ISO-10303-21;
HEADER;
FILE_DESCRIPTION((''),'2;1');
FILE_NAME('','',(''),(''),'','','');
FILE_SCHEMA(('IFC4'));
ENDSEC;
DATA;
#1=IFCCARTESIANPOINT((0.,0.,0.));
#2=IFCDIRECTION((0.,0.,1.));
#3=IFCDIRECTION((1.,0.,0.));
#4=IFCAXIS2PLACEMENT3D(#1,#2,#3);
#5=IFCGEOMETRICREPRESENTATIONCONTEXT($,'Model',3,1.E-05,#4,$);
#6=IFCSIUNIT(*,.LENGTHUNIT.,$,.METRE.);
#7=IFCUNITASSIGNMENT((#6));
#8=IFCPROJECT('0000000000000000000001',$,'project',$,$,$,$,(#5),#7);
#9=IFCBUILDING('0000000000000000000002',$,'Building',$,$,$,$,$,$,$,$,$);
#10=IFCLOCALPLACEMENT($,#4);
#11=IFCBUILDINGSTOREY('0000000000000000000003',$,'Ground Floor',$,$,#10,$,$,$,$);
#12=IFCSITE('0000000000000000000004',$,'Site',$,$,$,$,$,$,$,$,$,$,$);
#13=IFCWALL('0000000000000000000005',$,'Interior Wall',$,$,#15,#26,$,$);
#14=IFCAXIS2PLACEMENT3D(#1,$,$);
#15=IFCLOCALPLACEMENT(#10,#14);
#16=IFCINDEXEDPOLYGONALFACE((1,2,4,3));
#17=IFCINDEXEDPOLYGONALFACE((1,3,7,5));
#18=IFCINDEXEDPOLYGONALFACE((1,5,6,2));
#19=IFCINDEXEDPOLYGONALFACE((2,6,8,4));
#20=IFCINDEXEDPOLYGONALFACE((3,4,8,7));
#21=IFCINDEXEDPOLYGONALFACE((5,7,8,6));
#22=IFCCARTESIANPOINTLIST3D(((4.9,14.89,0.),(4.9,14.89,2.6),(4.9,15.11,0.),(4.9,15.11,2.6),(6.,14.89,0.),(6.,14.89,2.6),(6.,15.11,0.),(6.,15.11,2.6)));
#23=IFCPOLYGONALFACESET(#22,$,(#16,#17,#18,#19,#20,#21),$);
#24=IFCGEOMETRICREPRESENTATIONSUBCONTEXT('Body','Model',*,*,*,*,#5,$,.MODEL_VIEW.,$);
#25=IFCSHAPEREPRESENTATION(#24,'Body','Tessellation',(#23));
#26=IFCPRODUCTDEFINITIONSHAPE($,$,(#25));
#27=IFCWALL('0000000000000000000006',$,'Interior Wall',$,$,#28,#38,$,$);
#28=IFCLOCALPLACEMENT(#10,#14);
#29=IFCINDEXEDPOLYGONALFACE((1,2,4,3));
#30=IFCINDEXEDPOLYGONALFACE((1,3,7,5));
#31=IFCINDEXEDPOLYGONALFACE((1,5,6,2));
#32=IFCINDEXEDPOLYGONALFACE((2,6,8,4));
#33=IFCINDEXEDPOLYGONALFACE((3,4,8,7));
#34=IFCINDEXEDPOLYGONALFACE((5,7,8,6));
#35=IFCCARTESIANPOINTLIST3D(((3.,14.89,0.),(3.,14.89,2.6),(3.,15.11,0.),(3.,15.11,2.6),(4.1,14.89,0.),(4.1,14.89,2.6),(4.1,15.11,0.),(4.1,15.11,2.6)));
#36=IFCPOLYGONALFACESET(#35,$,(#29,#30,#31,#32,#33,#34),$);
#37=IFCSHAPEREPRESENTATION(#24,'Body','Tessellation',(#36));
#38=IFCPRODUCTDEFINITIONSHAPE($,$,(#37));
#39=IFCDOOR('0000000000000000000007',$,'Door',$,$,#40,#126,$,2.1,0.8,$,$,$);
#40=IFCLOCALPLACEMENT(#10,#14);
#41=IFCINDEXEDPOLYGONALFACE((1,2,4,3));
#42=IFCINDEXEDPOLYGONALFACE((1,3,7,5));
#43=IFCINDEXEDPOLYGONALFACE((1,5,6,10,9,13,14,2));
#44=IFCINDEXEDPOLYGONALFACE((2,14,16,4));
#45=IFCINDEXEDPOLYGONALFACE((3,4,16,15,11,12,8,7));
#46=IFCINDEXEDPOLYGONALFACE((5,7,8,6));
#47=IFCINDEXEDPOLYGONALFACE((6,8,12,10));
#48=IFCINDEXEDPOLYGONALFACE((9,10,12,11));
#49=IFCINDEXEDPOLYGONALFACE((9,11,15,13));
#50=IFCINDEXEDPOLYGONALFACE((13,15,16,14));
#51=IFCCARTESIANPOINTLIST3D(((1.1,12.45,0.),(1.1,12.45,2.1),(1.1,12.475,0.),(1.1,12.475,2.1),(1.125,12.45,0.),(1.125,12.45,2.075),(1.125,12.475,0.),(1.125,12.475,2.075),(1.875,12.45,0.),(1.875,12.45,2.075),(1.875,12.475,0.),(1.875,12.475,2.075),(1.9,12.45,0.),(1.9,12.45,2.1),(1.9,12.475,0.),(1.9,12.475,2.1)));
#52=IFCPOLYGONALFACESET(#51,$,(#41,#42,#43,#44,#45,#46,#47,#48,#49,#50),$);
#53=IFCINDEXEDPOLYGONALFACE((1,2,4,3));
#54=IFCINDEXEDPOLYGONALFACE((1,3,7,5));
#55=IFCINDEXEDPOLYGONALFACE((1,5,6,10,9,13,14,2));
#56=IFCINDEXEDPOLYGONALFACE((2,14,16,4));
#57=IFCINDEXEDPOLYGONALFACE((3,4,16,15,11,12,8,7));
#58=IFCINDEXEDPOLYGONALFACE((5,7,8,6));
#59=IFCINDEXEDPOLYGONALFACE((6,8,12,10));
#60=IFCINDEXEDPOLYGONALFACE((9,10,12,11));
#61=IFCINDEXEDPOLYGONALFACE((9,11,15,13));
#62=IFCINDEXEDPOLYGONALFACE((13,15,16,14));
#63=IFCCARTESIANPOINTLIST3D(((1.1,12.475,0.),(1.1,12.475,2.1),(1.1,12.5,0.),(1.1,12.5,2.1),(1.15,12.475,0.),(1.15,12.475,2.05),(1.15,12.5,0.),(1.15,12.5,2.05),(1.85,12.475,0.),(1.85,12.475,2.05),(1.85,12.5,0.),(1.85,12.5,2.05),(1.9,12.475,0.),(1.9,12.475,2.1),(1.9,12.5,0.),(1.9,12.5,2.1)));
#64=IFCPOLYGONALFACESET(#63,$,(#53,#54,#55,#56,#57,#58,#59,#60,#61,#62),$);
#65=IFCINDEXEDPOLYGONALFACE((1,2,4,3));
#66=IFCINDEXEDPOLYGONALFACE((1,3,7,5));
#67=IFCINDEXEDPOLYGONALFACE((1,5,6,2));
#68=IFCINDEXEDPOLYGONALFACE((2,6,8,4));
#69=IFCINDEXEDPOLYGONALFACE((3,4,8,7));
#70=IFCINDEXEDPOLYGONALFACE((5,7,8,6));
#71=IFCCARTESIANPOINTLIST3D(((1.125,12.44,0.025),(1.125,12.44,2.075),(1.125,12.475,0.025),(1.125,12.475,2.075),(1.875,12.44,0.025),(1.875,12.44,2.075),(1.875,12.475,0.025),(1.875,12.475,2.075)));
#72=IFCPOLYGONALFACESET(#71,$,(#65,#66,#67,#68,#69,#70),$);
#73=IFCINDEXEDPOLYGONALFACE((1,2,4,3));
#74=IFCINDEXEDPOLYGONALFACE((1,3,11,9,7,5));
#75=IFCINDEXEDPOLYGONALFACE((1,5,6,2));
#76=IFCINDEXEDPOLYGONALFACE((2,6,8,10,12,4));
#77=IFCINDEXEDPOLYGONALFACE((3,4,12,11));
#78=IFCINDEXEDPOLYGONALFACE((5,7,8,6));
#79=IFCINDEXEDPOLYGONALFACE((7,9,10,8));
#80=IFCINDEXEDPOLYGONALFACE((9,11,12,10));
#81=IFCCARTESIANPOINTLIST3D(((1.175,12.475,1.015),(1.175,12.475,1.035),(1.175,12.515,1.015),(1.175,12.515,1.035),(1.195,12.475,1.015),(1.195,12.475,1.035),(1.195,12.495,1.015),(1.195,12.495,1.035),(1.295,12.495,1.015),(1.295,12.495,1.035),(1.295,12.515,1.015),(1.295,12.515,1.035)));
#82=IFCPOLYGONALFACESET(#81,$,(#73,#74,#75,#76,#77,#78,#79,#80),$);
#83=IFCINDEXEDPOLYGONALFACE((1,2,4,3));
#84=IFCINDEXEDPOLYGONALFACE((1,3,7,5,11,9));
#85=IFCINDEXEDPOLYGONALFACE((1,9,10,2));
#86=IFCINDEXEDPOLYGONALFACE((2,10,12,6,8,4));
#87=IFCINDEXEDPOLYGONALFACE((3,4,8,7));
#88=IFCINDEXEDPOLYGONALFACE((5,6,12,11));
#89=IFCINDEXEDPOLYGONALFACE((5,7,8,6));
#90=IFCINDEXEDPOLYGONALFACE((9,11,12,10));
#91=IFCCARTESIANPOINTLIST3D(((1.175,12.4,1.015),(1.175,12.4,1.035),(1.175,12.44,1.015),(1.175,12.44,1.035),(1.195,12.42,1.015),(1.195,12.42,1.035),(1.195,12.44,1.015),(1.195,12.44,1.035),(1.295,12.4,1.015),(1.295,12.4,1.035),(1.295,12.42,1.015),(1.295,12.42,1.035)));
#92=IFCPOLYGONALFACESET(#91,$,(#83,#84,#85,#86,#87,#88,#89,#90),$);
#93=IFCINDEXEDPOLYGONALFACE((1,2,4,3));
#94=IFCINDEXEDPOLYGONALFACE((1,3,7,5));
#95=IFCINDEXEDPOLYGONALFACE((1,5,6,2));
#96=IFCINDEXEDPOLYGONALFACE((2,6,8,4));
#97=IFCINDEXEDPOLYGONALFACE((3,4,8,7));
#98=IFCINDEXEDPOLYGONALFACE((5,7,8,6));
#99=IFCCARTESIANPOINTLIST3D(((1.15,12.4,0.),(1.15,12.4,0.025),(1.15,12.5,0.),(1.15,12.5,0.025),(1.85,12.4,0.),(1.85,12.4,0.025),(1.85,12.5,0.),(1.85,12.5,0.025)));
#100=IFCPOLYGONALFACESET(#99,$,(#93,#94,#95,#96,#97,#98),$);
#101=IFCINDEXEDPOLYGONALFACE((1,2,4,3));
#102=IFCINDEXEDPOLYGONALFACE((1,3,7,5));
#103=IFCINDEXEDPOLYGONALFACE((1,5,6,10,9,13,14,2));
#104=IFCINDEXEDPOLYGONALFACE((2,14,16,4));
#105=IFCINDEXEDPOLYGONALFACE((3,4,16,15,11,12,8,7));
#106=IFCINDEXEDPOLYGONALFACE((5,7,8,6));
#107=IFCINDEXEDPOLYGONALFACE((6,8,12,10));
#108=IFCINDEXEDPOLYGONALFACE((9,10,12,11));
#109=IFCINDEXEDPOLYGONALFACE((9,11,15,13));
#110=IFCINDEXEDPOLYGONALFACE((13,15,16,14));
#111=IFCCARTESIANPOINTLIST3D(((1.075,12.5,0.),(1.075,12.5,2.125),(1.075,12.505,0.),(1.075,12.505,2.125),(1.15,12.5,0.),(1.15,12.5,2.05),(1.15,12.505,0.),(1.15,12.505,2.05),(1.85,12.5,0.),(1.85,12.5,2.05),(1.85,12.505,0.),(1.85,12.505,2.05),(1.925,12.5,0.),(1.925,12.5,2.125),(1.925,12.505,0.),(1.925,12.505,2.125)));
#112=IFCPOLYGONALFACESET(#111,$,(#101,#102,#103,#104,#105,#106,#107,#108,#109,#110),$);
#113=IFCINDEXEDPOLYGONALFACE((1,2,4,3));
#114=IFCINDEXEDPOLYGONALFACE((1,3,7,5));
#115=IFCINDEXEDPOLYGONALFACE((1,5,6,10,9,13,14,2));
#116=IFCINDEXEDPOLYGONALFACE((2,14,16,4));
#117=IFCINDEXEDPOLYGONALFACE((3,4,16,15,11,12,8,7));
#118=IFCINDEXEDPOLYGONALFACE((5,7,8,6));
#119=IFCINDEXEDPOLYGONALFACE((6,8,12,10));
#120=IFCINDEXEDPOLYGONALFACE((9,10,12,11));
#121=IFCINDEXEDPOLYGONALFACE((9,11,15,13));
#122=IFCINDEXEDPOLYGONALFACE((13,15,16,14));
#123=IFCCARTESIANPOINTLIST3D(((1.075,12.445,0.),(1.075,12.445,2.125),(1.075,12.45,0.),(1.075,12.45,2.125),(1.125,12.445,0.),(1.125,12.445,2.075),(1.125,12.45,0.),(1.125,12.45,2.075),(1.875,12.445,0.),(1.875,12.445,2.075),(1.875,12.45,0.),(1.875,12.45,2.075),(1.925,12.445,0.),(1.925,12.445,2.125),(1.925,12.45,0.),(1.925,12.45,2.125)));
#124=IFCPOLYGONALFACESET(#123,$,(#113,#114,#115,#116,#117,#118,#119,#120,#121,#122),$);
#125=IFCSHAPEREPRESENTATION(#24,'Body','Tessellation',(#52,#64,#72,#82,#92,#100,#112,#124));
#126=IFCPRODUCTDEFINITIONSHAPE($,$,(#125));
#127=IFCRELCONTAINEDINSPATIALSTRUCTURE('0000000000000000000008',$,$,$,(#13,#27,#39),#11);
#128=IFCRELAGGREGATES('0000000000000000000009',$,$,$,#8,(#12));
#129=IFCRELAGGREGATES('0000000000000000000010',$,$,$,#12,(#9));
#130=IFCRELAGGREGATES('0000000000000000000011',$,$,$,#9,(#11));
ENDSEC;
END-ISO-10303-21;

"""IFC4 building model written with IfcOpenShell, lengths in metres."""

from ifc_helpers import new_model, si_unit, frame, origin_with_axes, place, context, subcontext, project, spatial, line, indexed_curve, outline, extrude, element, save


model = new_model("IFC4")

# Units and contexts
model_context = context("Model", 3, precision=1e-05, world=origin_with_axes())
body_context = subcontext(model_context, "Body", "Model", "MODEL_VIEW")
ifc_project = project(units=[si_unit("LENGTHUNIT", "METRE")], contexts=[model_context])

# Site, building, storey
site = spatial("IfcSite", under=ifc_project, Name="Site")
building = spatial("IfcBuilding", under=site, Name="Building")
storey_placement = place(None, origin_with_axes())
storey = spatial("IfcBuildingStorey", under=building, at=storey_placement, Name="Ground Floor")

# Walls
for number, where, z_axis, x_axis, name in (
    (1, (6.0, 15.0, 0.0), (0.0, 0.0, 1.0), (-1.0, 0.0, 0.0), "Interior Wall"),
    (2, (4.1, 15.0, 0.0), (0.0, 0.0, 1.0), (-1.0, 0.0, 0.0), "Interior Wall"),
):
    element("IfcWall", number, at=place(storey_placement, frame(where, z_axis=z_axis, x_axis=x_axis)), inside=storey, Name=name, context=body_context, shape_type="SweptSolid", body=[
        extrude(outline(indexed_curve([(0.0, 0.0), (0.0, 0.22), (1.1, 0.22), (1.1, 0.0), (0.0, 0.0)], self_intersect=False)), frame((0.0, -0.11, 0.0), z_axis=(0.0, 0.0, 1.0), x_axis=(1.0, 0.0, 0.0)), (0.0, 0.0, 1.0), 2.6),
    ])

# Door
door_1_placement = place(storey_placement, frame((1.9, 12.5, 0.0), z_axis=(0.0, 0.0, 1.0), x_axis=(-1.0, 0.0, 0.0)))
element("IfcDoor", 3, at=door_1_placement, inside=storey, Name="Door", OverallHeight=2.1, OverallWidth=0.8, context=body_context, shape_type="SweptSolid", body=[
    extrude(outline(indexed_curve([(0.0, 0.0), (0.0, 2.1), (0.8, 2.1), (0.8, 0.0), (0.775, 0.0), (0.775, 2.075), (0.025, 2.075), (0.025, 0.0)], segments=[line(1, 2, 3, 4, 5, 6, 7, 8, 1)])), frame((0.0, 0.025, 0.0), z_axis=(0.0, -1.0, 0.0), x_axis=(1.0, 0.0, 0.0)), (0.0, 0.0, -1.0), 0.025),
    extrude(outline(indexed_curve([(0.0, 0.0), (0.0, 2.1), (0.8, 2.1), (0.8, 0.0), (0.75, 0.0), (0.75, 2.05), (0.05, 2.05), (0.05, 0.0)], segments=[line(1, 2, 3, 4, 5, 6, 7, 8, 1)])), frame((0.0, 0.0, 0.0), z_axis=(0.0, -1.0, 0.0), x_axis=(1.0, 0.0, 0.0)), (0.0, 0.0, -1.0), 0.025),
    extrude(outline(indexed_curve([(0.0, 0.0), (0.75, 0.0), (0.75, 0.035), (0.0, 0.035)], segments=[line(1, 2, 3, 4, 1)])), frame((0.025, 0.025, 0.025), z_axis=(0.0, 0.0, 1.0), x_axis=(1.0, 0.0, 0.0)), (0.0, 0.0, 1.0), 2.05),
    extrude(outline(indexed_curve([(0.0, 0.0), (0.0, -0.04), (-0.12, -0.04), (-0.12, -0.02), (-0.02, -0.02), (-0.02, 0.0)], segments=[line(1, 2, 3, 4, 5, 6, 1)])), frame((0.725, 0.025, 1.015), z_axis=(0.0, 0.0, 1.0), x_axis=(1.0, 0.0, 0.0)), (0.0, 0.0, 1.0), 0.02),
    extrude(outline(indexed_curve([(0.0, 0.0), (0.0, 0.04), (-0.12, 0.04), (-0.12, 0.02), (-0.02, 0.02), (-0.02, 0.0)], segments=[line(1, 2, 3, 4, 5, 6, 1)])), frame((0.725, 0.06, 1.015), z_axis=(0.0, 0.0, 1.0), x_axis=(1.0, 0.0, 0.0)), (0.0, 0.0, 1.0), 0.02),
    extrude(outline(indexed_curve([(0.0, 0.0), (0.7, 0.0), (0.7, 0.1), (0.0, 0.1)], segments=[line(1, 2, 3, 4, 1)])), frame((0.05, 0.0, 0.0), z_axis=(0.0, 0.0, 1.0), x_axis=(1.0, 0.0, 0.0)), (0.0, 0.0, 1.0), 0.025),
    extrude(outline(indexed_curve([(0.0, 0.0), (0.0, 2.125), (0.85, 2.125), (0.85, 0.0), (0.775, 0.0), (0.775, 2.05), (0.075, 2.05), (0.075, 0.0)], segments=[line(1, 2, 3, 4, 5, 6, 7, 8, 1)])), frame((-0.025, -0.005, 0.0), z_axis=(0.0, -1.0, 0.0), x_axis=(1.0, 0.0, 0.0)), (0.0, 0.0, -1.0), 0.005),
    extrude(outline(indexed_curve([(0.0, 0.0), (0.0, 2.125), (0.85, 2.125), (0.85, 0.0), (0.8, 0.0), (0.8, 2.075), (0.05, 2.075), (0.05, 0.0)], segments=[line(1, 2, 3, 4, 5, 6, 7, 8, 1)])), frame((-0.025, 0.05, 0.0), z_axis=(0.0, -1.0, 0.0), x_axis=(1.0, 0.0, 0.0)), (0.0, 0.0, -1.0), 0.005),
])

save(model, "model.ifc")
